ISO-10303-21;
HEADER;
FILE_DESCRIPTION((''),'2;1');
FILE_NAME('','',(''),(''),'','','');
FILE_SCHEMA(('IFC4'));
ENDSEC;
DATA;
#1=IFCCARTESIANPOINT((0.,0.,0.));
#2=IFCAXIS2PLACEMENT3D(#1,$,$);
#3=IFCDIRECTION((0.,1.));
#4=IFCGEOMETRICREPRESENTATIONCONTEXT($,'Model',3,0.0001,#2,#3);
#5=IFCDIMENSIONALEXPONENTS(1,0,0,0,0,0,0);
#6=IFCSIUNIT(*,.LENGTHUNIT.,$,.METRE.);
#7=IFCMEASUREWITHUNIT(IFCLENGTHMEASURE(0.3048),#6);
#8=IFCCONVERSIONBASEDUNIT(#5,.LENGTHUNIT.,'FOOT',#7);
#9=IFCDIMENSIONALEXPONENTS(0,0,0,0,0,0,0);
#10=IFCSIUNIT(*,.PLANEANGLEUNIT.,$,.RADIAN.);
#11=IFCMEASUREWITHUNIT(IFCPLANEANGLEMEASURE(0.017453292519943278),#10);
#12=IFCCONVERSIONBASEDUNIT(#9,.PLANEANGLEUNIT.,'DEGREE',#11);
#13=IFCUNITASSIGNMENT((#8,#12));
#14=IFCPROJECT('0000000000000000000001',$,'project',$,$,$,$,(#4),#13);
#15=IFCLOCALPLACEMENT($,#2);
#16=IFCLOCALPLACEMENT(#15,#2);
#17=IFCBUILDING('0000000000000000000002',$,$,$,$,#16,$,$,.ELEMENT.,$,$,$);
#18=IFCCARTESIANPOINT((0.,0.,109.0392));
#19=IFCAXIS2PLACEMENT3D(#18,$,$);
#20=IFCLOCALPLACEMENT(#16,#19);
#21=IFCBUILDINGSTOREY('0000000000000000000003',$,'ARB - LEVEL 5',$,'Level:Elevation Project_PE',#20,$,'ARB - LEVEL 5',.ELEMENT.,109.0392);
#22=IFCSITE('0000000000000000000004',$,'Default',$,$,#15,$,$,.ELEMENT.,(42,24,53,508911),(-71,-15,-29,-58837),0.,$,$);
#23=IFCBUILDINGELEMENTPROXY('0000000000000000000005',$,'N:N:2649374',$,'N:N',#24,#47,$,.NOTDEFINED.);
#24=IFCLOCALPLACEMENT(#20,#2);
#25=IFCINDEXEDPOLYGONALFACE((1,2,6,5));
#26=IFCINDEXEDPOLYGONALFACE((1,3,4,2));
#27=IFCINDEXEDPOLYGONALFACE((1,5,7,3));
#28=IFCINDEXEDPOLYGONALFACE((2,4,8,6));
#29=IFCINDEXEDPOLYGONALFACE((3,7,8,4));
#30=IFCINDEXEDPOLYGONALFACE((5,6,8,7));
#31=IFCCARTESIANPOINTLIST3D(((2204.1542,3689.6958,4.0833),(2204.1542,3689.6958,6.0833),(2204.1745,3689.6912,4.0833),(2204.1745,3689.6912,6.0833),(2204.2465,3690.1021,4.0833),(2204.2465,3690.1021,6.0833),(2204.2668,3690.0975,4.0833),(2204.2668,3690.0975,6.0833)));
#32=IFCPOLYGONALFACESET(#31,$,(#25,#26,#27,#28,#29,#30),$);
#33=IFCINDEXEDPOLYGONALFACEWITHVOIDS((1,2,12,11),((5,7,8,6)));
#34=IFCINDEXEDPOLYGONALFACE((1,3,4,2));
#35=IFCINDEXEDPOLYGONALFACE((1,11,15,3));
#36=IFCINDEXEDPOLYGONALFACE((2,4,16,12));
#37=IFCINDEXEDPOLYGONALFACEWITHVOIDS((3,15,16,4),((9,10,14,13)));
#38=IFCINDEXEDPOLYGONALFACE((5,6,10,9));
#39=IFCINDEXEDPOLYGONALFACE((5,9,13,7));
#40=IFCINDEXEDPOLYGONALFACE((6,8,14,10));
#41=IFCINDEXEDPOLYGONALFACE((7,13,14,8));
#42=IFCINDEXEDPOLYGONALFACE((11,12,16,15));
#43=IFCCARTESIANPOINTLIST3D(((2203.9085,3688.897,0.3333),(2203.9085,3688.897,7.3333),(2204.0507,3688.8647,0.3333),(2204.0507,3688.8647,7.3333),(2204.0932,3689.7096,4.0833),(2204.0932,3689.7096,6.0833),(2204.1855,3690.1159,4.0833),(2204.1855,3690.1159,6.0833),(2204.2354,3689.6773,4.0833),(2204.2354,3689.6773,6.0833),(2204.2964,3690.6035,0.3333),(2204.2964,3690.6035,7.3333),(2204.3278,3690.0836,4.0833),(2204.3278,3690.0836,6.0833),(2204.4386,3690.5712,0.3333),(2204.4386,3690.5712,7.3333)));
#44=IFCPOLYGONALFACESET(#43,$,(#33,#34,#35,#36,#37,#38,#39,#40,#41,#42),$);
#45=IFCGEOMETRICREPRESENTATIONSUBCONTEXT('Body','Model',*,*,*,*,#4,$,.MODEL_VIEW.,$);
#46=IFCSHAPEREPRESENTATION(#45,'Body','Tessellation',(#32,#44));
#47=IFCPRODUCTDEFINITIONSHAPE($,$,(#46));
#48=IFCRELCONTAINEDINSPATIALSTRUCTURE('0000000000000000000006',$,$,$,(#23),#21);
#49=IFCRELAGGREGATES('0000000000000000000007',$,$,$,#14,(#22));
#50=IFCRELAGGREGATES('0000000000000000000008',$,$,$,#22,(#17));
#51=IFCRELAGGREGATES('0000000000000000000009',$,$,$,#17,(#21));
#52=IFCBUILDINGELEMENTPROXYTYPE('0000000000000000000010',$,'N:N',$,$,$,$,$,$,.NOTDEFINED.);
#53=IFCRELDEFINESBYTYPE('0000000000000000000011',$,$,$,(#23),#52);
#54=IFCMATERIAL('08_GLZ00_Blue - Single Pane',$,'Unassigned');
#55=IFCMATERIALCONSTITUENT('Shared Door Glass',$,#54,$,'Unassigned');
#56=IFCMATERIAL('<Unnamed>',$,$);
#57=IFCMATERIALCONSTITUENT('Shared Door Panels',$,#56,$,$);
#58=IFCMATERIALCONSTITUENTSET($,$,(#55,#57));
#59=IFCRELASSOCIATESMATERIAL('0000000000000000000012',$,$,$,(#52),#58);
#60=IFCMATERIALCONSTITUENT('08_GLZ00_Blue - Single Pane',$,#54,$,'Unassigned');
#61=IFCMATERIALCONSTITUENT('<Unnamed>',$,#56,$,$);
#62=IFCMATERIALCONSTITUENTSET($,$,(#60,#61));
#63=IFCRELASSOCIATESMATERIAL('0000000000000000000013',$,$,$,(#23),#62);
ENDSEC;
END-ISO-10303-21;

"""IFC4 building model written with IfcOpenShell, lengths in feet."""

from ifc_helpers import new_model, entity, si_unit, converted_unit, direction, frame, origin, place, context, subcontext, project, spatial, indexed_curve, outline, extrude, source, transform, mapped, material, constituent, constituent_set, type_object, type_shapes, element, save


model = new_model("IFC4")

# Units and contexts
model_context = context("Model", 3, precision=0.0001, world=origin(), true_north=direction((0.0, 1.0)))
body_context = subcontext(model_context, "Body", "Model", "MODEL_VIEW")
ifc_project = project(units=[converted_unit("LENGTHUNIT", "FOOT", entity("IfcLengthMeasure", 0.3048), si_unit("LENGTHUNIT", "METRE"), dimensions=[1, 0, 0, 0, 0, 0, 0]), converted_unit("PLANEANGLEUNIT", "DEGREE", entity("IfcPlaneAngleMeasure", 0.017453292519943278), si_unit("PLANEANGLEUNIT", "RADIAN"), dimensions=[0, 0, 0, 0, 0, 0, 0])], contexts=[model_context])

# Site, building, storey
site_placement = place(None, origin())
site = spatial("IfcSite", under=ifc_project, at=site_placement, Name="Default", CompositionType="ELEMENT", RefLatitude=(42, 24, 53, 508911), RefLongitude=(-71, -15, -29, -58837), RefElevation=0.0)
building_placement = place(site_placement, origin())
building = spatial("IfcBuilding", under=site, at=building_placement, CompositionType="ELEMENT")
storey_placement = place(building_placement, frame((0.0, 0.0, 109.0392)))
storey = spatial("IfcBuildingStorey", under=building, at=storey_placement, Name="ARB - LEVEL 5", ObjectType="Level:Elevation Project_PE", LongName="ARB - LEVEL 5", CompositionType="ELEMENT", Elevation=109.0392)

# Shared definitions
ifc_material_1 = material(Name="<Unnamed>")

# Building element proxy
ifc_material_2 = material(Name="08_GLZ00_Blue - Single Pane", Category="Unassigned")
ifc_constituent_1 = constituent(ifc_material_2, Name="08_GLZ00_Blue - Single Pane", Category="Unassigned")
ifc_constituent_2 = constituent(ifc_material_1, Name="<Unnamed>")
ifc_constituent_set_1 = constituent_set(constituents=[ifc_constituent_1, ifc_constituent_2])
ifc_constituent_3 = constituent(ifc_material_2, Name="Shared Door Glass", Category="Unassigned")
ifc_constituent_4 = constituent(ifc_material_1, Name="Shared Door Panels")
ifc_constituent_set_2 = constituent_set(constituents=[ifc_constituent_3, ifc_constituent_4])
building_element_proxy_type_1 = type_object("IfcBuildingElementProxyType", Name="N:N", PredefinedType="NOTDEFINED", material=ifc_constituent_set_2)
shared_shape_1 = source(origin(), body_context, "Body", "SweptSolid", [
    extrude(outline(indexed_curve([(-0.2083, -0.0104), (0.2083, -0.0104), (0.2083, 0.0104), (-0.2083, 0.0104), (-0.2083, -0.0104)], self_intersect=False)), frame((-0.4525, -3.25, 3.75), z_axis=(0.0, 0.0, 1.0), x_axis=(-1.0, 0.0, 0.0)), (0.0, 0.0, 1.0), 2.0),
    extrude(outline(indexed_curve([(-3.5, -0.875), (3.5, -0.875), (3.5, 0.875), (-3.5, 0.875), (-3.5, -0.875)], self_intersect=False), holes=[indexed_curve([(-2.25, -0.0417), (-2.25, 0.375), (-0.25, 0.375), (-0.25, -0.0417), (-2.25, -0.0417)], self_intersect=False)]), frame((-0.2859, -3.3229, 3.5), z_axis=(0.0, 1.0, 0.0), x_axis=(0.0, 0.0, -1.0)), (0.0, 0.0, 1.0), 0.1458),
])
type_shapes(building_element_proxy_type_1, [shared_shape_1])
proxy_1_placement = place(storey_placement, frame((2207.2794, 3688.7351, 0.3333), z_axis=(0.0, 0.0, 1.0), x_axis=(-0.221622, -0.975133, 0.0)))
element("IfcBuildingElementProxy", 1, at=proxy_1_placement, inside=storey, type_object=building_element_proxy_type_1, material=ifc_constituent_set_1, Name="N:N:2649374", ObjectType="N:N", PredefinedType="NOTDEFINED", context=body_context, shape_type="MappedRepresentation", body=[
    mapped(shared_shape_1, transform((0.0, 0.0, 0.0), scale=1.0)),
])

save(model, "model.ifc")
